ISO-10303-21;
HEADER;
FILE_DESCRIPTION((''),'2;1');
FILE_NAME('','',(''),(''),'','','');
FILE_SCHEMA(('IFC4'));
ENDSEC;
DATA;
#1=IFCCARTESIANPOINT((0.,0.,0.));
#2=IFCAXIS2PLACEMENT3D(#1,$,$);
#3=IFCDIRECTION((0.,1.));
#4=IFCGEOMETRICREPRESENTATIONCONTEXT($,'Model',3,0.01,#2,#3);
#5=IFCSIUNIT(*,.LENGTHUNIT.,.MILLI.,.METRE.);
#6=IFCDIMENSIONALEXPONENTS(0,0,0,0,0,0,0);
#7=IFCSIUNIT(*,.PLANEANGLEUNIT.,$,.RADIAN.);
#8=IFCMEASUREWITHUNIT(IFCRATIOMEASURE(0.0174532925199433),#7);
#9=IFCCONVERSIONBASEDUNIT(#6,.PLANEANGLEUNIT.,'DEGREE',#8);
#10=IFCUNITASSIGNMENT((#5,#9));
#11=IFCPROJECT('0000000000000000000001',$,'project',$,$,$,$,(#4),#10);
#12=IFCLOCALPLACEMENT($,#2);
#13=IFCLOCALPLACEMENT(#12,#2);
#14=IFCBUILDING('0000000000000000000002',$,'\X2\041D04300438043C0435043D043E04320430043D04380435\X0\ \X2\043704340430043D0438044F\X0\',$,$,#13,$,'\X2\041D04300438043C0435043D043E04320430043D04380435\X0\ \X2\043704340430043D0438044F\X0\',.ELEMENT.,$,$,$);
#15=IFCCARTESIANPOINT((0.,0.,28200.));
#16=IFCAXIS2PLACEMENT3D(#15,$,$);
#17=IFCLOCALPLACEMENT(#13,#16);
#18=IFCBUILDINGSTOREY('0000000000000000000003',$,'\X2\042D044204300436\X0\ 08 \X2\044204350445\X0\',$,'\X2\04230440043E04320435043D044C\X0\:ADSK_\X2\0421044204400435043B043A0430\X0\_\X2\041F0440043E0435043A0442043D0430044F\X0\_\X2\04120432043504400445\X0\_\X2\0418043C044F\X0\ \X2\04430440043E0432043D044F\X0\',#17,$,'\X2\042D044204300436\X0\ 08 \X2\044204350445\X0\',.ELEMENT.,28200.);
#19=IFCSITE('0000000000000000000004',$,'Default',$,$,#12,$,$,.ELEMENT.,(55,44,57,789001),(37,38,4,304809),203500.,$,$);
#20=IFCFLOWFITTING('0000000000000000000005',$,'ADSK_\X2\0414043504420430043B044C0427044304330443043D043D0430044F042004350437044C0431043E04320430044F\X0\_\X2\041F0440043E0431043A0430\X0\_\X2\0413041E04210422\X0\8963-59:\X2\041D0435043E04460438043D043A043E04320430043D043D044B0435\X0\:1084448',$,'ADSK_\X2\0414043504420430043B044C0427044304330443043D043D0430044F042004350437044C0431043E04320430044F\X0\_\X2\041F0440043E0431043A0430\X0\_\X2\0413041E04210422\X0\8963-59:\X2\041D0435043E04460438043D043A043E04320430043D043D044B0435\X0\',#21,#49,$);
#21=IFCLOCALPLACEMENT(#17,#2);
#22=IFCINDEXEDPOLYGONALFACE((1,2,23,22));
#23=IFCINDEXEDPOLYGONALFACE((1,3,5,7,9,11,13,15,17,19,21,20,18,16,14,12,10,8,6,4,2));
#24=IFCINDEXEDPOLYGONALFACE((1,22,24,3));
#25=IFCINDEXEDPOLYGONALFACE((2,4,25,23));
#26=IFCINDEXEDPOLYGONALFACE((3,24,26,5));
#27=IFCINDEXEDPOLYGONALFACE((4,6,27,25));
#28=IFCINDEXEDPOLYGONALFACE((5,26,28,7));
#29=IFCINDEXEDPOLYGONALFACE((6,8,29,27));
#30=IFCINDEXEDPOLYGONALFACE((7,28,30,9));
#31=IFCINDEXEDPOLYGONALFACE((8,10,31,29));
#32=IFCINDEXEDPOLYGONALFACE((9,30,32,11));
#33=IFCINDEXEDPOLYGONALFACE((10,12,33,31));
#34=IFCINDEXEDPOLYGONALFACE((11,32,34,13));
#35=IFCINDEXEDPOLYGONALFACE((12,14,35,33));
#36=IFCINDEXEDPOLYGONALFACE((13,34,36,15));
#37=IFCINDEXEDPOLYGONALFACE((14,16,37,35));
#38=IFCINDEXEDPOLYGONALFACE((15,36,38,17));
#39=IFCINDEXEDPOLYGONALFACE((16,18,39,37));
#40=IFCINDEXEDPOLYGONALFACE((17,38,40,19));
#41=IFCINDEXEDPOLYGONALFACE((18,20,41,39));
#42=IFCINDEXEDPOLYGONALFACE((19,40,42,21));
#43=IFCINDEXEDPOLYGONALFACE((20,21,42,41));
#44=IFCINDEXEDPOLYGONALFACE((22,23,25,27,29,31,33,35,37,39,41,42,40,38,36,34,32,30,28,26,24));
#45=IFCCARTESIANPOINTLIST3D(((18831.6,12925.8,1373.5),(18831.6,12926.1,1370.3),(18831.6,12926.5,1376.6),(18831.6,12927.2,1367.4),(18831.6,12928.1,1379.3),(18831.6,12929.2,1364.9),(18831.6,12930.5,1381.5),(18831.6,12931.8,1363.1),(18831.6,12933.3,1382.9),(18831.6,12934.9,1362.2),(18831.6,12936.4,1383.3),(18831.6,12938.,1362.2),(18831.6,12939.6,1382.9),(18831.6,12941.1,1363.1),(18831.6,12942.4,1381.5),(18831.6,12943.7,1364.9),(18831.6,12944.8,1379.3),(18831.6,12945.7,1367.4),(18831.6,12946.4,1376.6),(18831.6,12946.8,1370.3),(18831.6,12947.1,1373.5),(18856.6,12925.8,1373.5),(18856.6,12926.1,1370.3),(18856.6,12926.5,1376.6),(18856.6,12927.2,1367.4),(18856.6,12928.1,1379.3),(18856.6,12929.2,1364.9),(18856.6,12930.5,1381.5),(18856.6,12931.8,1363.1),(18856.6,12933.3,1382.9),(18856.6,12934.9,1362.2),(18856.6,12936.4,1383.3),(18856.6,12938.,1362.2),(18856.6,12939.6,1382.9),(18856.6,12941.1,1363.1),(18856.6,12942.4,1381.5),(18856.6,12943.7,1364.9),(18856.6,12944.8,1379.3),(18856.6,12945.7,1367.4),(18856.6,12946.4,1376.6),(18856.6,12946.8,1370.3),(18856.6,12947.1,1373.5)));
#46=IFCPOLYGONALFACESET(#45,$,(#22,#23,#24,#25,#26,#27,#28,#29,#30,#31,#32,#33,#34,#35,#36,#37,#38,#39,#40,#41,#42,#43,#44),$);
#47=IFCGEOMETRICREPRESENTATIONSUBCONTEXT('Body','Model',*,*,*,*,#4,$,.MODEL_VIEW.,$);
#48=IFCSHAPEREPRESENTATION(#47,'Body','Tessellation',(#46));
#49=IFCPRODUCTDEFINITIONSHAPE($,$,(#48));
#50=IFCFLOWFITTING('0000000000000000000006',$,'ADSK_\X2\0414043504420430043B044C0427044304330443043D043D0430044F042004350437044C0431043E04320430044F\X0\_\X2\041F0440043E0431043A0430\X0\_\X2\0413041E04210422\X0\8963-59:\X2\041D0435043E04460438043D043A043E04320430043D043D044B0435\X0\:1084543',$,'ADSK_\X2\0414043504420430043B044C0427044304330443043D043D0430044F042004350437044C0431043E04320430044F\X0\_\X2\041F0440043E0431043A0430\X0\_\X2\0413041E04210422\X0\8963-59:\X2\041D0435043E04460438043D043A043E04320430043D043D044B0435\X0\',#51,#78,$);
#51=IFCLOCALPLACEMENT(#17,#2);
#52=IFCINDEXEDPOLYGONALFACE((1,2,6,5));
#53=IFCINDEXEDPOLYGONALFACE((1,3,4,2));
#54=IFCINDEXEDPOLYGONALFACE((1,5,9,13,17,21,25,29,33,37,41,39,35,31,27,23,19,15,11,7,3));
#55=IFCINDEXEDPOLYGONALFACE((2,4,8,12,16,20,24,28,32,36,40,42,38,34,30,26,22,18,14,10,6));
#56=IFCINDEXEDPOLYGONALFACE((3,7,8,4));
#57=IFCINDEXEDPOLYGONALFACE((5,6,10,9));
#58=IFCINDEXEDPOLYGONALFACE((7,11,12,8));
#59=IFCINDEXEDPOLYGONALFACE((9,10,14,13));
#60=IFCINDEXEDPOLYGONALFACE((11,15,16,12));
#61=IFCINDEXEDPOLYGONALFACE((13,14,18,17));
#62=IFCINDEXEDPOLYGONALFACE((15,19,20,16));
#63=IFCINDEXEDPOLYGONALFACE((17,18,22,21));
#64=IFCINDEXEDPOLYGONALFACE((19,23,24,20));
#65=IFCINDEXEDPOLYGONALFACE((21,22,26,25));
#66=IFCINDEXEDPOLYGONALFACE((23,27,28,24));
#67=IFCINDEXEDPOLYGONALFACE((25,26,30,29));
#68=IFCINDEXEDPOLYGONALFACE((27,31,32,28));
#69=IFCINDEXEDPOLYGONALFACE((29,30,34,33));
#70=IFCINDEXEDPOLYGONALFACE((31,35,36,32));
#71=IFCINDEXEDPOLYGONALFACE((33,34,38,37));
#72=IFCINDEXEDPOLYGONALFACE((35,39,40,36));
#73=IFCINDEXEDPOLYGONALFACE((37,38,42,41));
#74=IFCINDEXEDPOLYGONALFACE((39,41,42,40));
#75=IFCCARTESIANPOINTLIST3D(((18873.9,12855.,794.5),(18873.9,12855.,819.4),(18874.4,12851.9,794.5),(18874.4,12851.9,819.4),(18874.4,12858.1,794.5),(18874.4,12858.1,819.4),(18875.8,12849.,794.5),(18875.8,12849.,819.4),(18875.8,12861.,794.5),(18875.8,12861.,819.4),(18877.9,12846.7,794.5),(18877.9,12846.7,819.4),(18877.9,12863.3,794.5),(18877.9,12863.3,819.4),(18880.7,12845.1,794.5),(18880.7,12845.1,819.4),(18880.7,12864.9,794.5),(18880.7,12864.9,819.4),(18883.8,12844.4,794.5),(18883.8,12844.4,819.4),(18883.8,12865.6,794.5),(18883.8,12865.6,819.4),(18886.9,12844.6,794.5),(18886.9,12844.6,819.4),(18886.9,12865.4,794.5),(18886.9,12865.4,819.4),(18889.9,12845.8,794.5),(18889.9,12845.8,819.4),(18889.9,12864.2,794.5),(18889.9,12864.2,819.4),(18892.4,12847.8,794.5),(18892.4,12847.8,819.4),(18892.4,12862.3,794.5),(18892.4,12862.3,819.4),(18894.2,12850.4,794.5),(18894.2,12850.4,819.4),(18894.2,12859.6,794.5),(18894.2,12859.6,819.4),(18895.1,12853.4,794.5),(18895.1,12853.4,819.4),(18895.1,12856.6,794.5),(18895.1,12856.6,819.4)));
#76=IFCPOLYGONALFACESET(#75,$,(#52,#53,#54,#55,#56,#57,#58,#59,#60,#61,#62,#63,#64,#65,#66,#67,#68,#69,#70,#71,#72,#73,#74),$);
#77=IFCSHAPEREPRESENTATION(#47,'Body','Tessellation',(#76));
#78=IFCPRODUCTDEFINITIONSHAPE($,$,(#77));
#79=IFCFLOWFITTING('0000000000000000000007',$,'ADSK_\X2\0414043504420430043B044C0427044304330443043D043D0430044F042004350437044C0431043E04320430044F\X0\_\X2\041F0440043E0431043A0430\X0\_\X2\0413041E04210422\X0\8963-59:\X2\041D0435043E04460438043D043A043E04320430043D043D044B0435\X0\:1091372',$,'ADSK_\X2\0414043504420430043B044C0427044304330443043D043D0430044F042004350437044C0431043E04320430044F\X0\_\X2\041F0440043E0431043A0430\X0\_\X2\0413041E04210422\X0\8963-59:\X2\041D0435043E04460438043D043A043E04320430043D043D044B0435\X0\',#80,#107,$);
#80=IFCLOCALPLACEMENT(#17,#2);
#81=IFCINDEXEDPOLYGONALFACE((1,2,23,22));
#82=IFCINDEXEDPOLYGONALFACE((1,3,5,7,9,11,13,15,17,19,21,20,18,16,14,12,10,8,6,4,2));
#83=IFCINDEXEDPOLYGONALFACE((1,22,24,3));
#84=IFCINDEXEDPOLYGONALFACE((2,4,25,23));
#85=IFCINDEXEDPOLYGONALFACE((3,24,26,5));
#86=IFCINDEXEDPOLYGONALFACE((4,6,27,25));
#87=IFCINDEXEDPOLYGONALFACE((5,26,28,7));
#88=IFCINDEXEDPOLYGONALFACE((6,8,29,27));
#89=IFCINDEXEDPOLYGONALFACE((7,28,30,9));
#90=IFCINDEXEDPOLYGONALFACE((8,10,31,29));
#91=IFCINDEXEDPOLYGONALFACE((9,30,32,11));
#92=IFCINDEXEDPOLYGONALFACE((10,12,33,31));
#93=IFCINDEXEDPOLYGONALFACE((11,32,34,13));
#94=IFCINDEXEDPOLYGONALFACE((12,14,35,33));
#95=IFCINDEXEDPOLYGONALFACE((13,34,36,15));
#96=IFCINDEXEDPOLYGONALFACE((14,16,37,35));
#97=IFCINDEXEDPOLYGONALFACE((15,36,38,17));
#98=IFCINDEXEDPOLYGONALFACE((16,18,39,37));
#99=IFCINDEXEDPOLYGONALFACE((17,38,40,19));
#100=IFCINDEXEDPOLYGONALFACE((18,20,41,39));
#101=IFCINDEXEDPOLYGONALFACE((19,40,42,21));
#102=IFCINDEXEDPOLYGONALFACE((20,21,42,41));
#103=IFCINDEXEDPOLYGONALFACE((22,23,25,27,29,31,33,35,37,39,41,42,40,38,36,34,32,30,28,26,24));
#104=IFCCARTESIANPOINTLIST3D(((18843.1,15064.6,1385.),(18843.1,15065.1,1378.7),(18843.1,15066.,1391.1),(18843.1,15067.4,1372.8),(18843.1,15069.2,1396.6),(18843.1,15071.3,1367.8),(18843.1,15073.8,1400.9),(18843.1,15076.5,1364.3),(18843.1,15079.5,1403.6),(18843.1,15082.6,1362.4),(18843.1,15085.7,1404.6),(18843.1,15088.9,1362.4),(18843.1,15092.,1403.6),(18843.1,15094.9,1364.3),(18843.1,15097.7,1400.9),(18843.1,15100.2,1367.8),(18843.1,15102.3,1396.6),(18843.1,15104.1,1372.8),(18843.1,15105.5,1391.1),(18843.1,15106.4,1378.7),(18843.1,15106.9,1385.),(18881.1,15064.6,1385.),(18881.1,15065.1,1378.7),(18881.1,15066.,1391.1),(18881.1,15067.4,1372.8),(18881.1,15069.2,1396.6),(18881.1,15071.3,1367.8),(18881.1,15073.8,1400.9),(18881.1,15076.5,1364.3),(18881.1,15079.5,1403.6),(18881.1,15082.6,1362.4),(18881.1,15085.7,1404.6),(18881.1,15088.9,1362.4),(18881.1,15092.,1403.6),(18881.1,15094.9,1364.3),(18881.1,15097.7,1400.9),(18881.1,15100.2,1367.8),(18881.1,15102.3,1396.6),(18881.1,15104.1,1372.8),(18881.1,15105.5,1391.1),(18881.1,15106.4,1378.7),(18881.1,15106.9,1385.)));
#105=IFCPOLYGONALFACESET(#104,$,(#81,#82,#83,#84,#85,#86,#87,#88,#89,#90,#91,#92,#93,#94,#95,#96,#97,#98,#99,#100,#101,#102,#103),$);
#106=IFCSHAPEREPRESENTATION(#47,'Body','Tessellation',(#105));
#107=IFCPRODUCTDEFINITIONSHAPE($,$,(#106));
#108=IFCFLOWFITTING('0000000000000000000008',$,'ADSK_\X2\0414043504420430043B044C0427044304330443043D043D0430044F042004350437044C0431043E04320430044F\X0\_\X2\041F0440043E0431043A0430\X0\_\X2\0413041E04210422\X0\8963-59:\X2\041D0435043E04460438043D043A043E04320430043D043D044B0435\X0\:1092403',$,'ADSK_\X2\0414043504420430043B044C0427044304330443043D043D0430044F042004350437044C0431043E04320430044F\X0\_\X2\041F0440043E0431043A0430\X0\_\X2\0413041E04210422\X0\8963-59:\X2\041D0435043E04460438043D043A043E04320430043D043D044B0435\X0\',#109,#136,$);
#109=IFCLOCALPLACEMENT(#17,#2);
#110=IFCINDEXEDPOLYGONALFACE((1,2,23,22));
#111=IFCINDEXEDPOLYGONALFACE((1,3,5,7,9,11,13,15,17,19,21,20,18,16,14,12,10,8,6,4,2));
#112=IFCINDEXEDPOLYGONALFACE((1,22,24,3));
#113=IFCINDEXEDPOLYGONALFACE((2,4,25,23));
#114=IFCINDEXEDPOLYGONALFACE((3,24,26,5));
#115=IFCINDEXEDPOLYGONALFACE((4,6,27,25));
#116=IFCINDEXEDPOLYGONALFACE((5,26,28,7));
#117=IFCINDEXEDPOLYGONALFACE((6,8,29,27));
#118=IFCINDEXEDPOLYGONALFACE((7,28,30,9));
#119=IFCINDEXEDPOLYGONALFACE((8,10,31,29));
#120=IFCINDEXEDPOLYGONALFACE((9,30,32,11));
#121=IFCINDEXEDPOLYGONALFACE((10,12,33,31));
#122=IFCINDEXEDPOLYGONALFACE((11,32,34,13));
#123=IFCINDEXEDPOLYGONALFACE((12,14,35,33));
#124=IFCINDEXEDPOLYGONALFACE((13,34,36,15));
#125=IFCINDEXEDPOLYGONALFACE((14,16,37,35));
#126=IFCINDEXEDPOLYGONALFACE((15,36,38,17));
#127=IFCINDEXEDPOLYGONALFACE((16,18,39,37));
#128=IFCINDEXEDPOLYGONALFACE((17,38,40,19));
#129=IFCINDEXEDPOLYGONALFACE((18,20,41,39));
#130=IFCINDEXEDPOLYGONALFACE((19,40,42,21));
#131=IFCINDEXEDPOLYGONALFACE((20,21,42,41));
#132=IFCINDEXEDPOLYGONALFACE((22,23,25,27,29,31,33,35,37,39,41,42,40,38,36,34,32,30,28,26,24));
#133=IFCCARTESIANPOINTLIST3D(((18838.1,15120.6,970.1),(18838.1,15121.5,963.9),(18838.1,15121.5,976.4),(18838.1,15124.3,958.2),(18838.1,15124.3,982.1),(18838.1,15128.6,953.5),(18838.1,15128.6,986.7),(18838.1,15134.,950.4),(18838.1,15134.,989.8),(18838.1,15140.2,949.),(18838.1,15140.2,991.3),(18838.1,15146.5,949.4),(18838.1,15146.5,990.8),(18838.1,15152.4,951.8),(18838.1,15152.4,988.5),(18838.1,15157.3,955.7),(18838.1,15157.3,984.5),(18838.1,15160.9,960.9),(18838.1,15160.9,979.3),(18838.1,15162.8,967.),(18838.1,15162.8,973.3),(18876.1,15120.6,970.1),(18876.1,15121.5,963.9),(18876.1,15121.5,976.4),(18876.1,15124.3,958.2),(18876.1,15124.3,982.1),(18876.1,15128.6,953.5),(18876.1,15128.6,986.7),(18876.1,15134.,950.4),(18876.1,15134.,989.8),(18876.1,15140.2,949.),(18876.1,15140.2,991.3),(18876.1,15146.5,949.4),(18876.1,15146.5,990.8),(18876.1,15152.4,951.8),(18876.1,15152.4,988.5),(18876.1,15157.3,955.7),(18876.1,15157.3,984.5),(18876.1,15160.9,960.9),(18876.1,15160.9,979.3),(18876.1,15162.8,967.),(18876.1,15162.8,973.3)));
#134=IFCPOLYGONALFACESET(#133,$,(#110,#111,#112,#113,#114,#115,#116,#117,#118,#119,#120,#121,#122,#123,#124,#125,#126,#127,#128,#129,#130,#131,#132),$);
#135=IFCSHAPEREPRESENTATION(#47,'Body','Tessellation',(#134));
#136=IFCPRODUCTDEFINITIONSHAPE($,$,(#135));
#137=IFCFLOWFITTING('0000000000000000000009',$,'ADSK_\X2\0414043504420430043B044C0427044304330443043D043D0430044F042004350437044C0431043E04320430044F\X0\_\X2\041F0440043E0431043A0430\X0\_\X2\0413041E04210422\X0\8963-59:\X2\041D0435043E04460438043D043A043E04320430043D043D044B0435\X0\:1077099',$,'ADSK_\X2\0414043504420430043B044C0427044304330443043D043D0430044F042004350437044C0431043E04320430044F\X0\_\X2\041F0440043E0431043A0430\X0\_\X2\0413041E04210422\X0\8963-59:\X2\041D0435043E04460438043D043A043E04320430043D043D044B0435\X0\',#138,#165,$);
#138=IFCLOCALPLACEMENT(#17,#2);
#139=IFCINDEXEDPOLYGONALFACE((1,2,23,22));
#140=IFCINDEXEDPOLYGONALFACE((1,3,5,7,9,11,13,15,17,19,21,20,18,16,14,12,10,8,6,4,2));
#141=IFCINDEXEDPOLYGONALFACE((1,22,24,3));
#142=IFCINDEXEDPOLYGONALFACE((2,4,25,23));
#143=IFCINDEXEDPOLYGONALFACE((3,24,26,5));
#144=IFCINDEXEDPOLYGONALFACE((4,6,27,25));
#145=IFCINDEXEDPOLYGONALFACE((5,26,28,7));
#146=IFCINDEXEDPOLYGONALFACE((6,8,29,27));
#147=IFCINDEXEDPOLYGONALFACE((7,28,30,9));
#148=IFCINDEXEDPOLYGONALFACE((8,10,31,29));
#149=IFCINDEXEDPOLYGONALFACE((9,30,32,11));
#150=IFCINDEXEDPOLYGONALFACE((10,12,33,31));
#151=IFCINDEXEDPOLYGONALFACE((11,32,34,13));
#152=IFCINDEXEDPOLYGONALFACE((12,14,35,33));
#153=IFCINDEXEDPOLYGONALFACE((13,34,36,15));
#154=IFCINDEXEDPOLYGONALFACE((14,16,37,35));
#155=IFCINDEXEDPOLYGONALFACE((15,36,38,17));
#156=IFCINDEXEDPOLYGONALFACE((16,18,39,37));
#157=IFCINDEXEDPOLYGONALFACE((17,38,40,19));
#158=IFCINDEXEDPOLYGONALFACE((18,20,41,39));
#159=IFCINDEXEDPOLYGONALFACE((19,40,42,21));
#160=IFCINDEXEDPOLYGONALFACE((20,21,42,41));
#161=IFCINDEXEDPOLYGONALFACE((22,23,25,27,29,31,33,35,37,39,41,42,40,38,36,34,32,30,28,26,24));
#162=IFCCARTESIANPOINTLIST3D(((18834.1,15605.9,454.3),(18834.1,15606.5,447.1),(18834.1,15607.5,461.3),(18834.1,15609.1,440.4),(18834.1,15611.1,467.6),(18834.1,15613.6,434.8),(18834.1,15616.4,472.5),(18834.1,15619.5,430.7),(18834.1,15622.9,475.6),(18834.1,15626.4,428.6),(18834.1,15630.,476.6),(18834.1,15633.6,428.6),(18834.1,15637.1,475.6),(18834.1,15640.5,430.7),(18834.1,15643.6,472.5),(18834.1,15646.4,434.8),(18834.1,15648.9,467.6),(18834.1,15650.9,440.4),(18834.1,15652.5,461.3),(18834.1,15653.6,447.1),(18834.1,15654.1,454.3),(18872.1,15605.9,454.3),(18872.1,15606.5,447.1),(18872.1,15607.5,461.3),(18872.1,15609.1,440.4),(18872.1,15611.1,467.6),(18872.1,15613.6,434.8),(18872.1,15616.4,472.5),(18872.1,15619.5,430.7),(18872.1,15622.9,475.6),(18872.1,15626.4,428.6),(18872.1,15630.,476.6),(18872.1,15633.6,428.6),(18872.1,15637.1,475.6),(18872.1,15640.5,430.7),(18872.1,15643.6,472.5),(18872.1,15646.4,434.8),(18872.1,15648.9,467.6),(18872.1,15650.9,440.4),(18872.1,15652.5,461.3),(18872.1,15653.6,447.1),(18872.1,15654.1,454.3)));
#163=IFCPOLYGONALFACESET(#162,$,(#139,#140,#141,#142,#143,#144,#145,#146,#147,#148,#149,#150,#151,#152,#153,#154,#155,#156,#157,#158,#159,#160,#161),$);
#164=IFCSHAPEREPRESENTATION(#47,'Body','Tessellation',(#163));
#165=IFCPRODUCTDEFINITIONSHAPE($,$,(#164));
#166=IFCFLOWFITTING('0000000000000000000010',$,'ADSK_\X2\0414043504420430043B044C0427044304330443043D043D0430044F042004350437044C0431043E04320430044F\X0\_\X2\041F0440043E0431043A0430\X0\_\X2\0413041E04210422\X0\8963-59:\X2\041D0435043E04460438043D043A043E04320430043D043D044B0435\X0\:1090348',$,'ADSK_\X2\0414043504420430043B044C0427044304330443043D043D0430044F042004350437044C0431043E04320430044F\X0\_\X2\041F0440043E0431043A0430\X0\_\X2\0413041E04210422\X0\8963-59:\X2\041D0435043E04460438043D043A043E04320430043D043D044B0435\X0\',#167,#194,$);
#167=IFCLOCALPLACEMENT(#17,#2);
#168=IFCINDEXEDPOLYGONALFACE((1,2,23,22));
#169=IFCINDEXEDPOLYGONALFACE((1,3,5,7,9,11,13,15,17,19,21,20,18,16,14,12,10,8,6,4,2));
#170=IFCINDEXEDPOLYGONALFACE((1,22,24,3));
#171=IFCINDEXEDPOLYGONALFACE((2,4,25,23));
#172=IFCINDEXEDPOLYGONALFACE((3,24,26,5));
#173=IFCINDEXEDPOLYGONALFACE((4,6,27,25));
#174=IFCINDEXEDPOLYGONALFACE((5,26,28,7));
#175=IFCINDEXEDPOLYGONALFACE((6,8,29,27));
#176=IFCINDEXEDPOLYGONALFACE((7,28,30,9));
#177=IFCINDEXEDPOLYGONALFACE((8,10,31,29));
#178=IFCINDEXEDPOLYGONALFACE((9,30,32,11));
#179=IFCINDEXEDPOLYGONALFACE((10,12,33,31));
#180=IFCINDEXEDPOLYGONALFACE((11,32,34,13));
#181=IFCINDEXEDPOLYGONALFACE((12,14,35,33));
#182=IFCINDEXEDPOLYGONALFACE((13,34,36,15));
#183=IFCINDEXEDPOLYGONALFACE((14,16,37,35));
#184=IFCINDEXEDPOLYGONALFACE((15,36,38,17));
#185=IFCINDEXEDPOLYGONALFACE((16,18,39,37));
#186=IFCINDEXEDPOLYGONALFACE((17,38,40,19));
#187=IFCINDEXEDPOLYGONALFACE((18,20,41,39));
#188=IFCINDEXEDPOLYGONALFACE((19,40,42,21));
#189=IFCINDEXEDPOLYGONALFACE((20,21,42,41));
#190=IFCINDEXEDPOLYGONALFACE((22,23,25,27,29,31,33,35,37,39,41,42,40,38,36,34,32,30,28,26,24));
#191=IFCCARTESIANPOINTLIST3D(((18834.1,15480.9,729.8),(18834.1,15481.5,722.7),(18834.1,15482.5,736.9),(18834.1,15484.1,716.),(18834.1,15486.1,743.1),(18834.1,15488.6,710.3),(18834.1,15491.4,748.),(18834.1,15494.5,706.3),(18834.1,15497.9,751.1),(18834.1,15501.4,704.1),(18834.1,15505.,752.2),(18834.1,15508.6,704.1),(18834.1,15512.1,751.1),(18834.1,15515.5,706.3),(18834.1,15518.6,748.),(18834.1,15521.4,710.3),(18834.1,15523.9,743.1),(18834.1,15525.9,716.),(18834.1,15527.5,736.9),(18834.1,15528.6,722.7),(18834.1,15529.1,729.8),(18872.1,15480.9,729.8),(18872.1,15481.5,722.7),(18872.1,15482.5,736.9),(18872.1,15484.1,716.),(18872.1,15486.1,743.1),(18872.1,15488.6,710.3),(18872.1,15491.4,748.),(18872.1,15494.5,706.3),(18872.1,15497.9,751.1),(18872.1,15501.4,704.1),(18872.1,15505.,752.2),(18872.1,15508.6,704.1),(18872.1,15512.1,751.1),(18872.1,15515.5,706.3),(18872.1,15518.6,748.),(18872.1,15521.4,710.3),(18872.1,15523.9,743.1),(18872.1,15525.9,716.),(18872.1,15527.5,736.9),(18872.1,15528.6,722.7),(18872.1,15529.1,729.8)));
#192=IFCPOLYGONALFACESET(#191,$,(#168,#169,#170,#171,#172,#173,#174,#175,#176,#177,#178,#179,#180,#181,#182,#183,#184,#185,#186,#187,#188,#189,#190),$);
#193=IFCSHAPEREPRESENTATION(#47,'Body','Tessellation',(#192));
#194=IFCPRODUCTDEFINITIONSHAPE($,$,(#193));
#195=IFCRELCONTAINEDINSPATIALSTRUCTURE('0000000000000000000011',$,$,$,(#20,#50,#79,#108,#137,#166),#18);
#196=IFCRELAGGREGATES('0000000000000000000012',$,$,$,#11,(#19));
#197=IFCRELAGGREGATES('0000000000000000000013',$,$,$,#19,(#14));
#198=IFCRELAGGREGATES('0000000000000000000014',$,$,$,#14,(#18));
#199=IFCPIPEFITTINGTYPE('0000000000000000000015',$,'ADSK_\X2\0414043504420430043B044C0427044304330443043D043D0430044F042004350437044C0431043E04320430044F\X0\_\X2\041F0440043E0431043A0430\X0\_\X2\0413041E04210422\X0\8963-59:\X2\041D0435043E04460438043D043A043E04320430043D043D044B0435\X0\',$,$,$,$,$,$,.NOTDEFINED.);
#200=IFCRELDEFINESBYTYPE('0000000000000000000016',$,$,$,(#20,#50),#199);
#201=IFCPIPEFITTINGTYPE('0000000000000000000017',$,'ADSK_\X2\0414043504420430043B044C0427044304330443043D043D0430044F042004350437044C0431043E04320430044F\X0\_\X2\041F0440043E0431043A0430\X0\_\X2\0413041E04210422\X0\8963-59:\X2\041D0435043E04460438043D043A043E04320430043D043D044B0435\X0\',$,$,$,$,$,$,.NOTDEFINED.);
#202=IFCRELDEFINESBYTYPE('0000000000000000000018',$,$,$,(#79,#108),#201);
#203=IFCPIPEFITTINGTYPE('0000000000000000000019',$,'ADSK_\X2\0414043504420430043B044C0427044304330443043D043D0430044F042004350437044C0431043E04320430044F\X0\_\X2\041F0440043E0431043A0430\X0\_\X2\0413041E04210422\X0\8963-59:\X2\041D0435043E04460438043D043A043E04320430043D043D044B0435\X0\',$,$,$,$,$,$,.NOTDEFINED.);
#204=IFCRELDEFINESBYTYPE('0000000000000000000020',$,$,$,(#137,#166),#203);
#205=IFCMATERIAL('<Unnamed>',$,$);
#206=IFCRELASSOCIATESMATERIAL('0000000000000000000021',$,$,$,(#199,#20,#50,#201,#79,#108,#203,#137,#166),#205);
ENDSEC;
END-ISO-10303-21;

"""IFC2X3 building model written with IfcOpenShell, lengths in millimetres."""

from ifc_helpers import new_model, entity, si_unit, converted_unit, direction, frame, origin, origin_2d_with_axis, place, context, subcontext, project, spatial, circle, extrude, source, transform, mapped, material, type_object, type_shapes, element, save


model = new_model("IFC2X3")

# Units and contexts
model_context = context("Model", 3, precision=0.01, world=origin(), true_north=direction((0.0, 1.0)))
body_context = subcontext(model_context, "Body", "Model", "MODEL_VIEW")
ifc_project = project(units=[si_unit("LENGTHUNIT", "METRE", prefix="MILLI"), converted_unit("PLANEANGLEUNIT", "DEGREE", entity("IfcRatioMeasure", 0.0174532925199433), si_unit("PLANEANGLEUNIT", "RADIAN"), dimensions=[0, 0, 0, 0, 0, 0, 0])], contexts=[model_context])

# Site, building, storey
site_placement = place(None, origin())
site = spatial("IfcSite", under=ifc_project, at=site_placement, Name="Default", CompositionType="ELEMENT", RefLatitude=(55, 44, 57, 789001), RefLongitude=(37, 38, 4, 304809), RefElevation=203500.0)
building_placement = place(site_placement, origin())
building = spatial("IfcBuilding", under=site, at=building_placement, Name="Наименование здания", LongName="Наименование здания", CompositionType="ELEMENT")
storey_placement = place(building_placement, frame((0.0, 0.0, 28200.0)))
storey = spatial("IfcBuildingStorey", under=building, at=storey_placement, Name="Этаж 08 тех", ObjectType="Уровень:ADSK_Стрелка_Проектная_Вверх_Имя уровня", LongName="Этаж 08 тех", CompositionType="ELEMENT", Elevation=28200.0)

# Flow fittings
ifc_material = material(Name="<Unnamed>")
pipe_fitting_type_1 = type_object("IfcPipeFittingType", Name="ADSK_ДетальЧугуннаяРезьбовая_Пробка_ГОСТ8963-59:Неоцинкованные", PredefinedType="NOTDEFINED", material=ifc_material)
shared_shape_1 = source(origin(), body_context, "Body", "SweptSolid", [
    extrude(circle(Radius=10.7, at=origin_2d_with_axis()), frame((0.0, 0.0, 0.0), z_axis=(1.0, 0.0, 0.0), x_axis=(0.0, 1.0, 0.0)), (0.0, 0.0, 1.0), 25.0),
])
type_shapes(pipe_fitting_type_1, [shared_shape_1])
for number, where, z_axis, x_axis, name in (
    (1, (18856.6, 12936.5, 1372.7), (0.0, 1.0, 0.0), (-1.0, 0.0, 0.0), "ADSK_ДетальЧугуннаяРезьбовая_Пробка_ГОСТ8963-59:Неоцинкованные:1084448"),
    (2, (18884.6, 12855.0, 819.5), (0.0, 1.0, 0.0), (0.0, 0.0, -1.0), "ADSK_ДетальЧугуннаяРезьбовая_Пробка_ГОСТ8963-59:Неоцинкованные:1084543"),
):
    element("IfcFlowFitting", number, at=place(storey_placement, frame(where, z_axis=z_axis, x_axis=x_axis)), inside=storey, type_object=pipe_fitting_type_1, material=ifc_material, Name=name, ObjectType="ADSK_ДетальЧугуннаяРезьбовая_Пробка_ГОСТ8963-59:Неоцинкованные", context=body_context, shape_type="MappedRepresentation", body=[
        mapped(shared_shape_1, transform((0.0, 0.0, 0.0), scale=1.0)),
    ])
pipe_fitting_type_2 = type_object("IfcPipeFittingType", Name="ADSK_ДетальЧугуннаяРезьбовая_Пробка_ГОСТ8963-59:Неоцинкованные", PredefinedType="NOTDEFINED", material=ifc_material)
shared_shape_2 = source(origin(), body_context, "Body", "SweptSolid", [
    extrude(circle(Radius=21.2, at=origin_2d_with_axis()), frame((0.0, 0.0, 0.0), z_axis=(1.0, 0.0, 0.0), x_axis=(0.0, 1.0, 0.0)), (0.0, 0.0, 1.0), 38.0),
])
type_shapes(pipe_fitting_type_2, [shared_shape_2])
for number, where, z_axis, x_axis, name in (
    (3, (18881.1, 15085.7, 1383.4), (0.0, 1.0, 0.0), (-1.0, 0.0, 0.0), "ADSK_ДетальЧугуннаяРезьбовая_Пробка_ГОСТ8963-59:Неоцинкованные:1091372"),
    (4, (18876.1, 15141.8, 970.1), (0.0, 0.0, 1.0), (-1.0, 0.0, 0.0), "ADSK_ДетальЧугуннаяРезьбовая_Пробка_ГОСТ8963-59:Неоцинкованные:1092403"),
):
    element("IfcFlowFitting", number, at=place(storey_placement, frame(where, z_axis=z_axis, x_axis=x_axis)), inside=storey, type_object=pipe_fitting_type_2, material=ifc_material, Name=name, ObjectType="ADSK_ДетальЧугуннаяРезьбовая_Пробка_ГОСТ8963-59:Неоцинкованные", context=body_context, shape_type="MappedRepresentation", body=[
        mapped(shared_shape_2, transform((0.0, 0.0, 0.0), scale=1.0)),
    ])
pipe_fitting_type_3 = type_object("IfcPipeFittingType", Name="ADSK_ДетальЧугуннаяРезьбовая_Пробка_ГОСТ8963-59:Неоцинкованные", PredefinedType="NOTDEFINED", material=ifc_material)
shared_shape_3 = source(origin(), body_context, "Body", "SweptSolid", [
    extrude(circle(Radius=24.1, at=origin_2d_with_axis()), frame((0.0, 0.0, 0.0), z_axis=(1.0, 0.0, 0.0), x_axis=(0.0, 1.0, 0.0)), (0.0, 0.0, 1.0), 38.0),
])
type_shapes(pipe_fitting_type_3, [shared_shape_3])
for number, where, z_axis, x_axis, name in (
    (5, (18872.1, 15630.0, 452.5), (0.0, 1.0, 0.0), (-1.0, 0.0, 0.0), "ADSK_ДетальЧугуннаяРезьбовая_Пробка_ГОСТ8963-59:Неоцинкованные:1077099"),
    (6, (18872.1, 15505.0, 728.0), (0.0, 1.0, 0.0), (-1.0, 0.0, 0.0), "ADSK_ДетальЧугуннаяРезьбовая_Пробка_ГОСТ8963-59:Неоцинкованные:1090348"),
):
    element("IfcFlowFitting", number, at=place(storey_placement, frame(where, z_axis=z_axis, x_axis=x_axis)), inside=storey, type_object=pipe_fitting_type_3, material=ifc_material, Name=name, ObjectType="ADSK_ДетальЧугуннаяРезьбовая_Пробка_ГОСТ8963-59:Неоцинкованные", context=body_context, shape_type="MappedRepresentation", body=[
        mapped(shared_shape_3, transform((0.0, 0.0, 0.0), scale=1.0)),
    ])

save(model, "model.ifc")
